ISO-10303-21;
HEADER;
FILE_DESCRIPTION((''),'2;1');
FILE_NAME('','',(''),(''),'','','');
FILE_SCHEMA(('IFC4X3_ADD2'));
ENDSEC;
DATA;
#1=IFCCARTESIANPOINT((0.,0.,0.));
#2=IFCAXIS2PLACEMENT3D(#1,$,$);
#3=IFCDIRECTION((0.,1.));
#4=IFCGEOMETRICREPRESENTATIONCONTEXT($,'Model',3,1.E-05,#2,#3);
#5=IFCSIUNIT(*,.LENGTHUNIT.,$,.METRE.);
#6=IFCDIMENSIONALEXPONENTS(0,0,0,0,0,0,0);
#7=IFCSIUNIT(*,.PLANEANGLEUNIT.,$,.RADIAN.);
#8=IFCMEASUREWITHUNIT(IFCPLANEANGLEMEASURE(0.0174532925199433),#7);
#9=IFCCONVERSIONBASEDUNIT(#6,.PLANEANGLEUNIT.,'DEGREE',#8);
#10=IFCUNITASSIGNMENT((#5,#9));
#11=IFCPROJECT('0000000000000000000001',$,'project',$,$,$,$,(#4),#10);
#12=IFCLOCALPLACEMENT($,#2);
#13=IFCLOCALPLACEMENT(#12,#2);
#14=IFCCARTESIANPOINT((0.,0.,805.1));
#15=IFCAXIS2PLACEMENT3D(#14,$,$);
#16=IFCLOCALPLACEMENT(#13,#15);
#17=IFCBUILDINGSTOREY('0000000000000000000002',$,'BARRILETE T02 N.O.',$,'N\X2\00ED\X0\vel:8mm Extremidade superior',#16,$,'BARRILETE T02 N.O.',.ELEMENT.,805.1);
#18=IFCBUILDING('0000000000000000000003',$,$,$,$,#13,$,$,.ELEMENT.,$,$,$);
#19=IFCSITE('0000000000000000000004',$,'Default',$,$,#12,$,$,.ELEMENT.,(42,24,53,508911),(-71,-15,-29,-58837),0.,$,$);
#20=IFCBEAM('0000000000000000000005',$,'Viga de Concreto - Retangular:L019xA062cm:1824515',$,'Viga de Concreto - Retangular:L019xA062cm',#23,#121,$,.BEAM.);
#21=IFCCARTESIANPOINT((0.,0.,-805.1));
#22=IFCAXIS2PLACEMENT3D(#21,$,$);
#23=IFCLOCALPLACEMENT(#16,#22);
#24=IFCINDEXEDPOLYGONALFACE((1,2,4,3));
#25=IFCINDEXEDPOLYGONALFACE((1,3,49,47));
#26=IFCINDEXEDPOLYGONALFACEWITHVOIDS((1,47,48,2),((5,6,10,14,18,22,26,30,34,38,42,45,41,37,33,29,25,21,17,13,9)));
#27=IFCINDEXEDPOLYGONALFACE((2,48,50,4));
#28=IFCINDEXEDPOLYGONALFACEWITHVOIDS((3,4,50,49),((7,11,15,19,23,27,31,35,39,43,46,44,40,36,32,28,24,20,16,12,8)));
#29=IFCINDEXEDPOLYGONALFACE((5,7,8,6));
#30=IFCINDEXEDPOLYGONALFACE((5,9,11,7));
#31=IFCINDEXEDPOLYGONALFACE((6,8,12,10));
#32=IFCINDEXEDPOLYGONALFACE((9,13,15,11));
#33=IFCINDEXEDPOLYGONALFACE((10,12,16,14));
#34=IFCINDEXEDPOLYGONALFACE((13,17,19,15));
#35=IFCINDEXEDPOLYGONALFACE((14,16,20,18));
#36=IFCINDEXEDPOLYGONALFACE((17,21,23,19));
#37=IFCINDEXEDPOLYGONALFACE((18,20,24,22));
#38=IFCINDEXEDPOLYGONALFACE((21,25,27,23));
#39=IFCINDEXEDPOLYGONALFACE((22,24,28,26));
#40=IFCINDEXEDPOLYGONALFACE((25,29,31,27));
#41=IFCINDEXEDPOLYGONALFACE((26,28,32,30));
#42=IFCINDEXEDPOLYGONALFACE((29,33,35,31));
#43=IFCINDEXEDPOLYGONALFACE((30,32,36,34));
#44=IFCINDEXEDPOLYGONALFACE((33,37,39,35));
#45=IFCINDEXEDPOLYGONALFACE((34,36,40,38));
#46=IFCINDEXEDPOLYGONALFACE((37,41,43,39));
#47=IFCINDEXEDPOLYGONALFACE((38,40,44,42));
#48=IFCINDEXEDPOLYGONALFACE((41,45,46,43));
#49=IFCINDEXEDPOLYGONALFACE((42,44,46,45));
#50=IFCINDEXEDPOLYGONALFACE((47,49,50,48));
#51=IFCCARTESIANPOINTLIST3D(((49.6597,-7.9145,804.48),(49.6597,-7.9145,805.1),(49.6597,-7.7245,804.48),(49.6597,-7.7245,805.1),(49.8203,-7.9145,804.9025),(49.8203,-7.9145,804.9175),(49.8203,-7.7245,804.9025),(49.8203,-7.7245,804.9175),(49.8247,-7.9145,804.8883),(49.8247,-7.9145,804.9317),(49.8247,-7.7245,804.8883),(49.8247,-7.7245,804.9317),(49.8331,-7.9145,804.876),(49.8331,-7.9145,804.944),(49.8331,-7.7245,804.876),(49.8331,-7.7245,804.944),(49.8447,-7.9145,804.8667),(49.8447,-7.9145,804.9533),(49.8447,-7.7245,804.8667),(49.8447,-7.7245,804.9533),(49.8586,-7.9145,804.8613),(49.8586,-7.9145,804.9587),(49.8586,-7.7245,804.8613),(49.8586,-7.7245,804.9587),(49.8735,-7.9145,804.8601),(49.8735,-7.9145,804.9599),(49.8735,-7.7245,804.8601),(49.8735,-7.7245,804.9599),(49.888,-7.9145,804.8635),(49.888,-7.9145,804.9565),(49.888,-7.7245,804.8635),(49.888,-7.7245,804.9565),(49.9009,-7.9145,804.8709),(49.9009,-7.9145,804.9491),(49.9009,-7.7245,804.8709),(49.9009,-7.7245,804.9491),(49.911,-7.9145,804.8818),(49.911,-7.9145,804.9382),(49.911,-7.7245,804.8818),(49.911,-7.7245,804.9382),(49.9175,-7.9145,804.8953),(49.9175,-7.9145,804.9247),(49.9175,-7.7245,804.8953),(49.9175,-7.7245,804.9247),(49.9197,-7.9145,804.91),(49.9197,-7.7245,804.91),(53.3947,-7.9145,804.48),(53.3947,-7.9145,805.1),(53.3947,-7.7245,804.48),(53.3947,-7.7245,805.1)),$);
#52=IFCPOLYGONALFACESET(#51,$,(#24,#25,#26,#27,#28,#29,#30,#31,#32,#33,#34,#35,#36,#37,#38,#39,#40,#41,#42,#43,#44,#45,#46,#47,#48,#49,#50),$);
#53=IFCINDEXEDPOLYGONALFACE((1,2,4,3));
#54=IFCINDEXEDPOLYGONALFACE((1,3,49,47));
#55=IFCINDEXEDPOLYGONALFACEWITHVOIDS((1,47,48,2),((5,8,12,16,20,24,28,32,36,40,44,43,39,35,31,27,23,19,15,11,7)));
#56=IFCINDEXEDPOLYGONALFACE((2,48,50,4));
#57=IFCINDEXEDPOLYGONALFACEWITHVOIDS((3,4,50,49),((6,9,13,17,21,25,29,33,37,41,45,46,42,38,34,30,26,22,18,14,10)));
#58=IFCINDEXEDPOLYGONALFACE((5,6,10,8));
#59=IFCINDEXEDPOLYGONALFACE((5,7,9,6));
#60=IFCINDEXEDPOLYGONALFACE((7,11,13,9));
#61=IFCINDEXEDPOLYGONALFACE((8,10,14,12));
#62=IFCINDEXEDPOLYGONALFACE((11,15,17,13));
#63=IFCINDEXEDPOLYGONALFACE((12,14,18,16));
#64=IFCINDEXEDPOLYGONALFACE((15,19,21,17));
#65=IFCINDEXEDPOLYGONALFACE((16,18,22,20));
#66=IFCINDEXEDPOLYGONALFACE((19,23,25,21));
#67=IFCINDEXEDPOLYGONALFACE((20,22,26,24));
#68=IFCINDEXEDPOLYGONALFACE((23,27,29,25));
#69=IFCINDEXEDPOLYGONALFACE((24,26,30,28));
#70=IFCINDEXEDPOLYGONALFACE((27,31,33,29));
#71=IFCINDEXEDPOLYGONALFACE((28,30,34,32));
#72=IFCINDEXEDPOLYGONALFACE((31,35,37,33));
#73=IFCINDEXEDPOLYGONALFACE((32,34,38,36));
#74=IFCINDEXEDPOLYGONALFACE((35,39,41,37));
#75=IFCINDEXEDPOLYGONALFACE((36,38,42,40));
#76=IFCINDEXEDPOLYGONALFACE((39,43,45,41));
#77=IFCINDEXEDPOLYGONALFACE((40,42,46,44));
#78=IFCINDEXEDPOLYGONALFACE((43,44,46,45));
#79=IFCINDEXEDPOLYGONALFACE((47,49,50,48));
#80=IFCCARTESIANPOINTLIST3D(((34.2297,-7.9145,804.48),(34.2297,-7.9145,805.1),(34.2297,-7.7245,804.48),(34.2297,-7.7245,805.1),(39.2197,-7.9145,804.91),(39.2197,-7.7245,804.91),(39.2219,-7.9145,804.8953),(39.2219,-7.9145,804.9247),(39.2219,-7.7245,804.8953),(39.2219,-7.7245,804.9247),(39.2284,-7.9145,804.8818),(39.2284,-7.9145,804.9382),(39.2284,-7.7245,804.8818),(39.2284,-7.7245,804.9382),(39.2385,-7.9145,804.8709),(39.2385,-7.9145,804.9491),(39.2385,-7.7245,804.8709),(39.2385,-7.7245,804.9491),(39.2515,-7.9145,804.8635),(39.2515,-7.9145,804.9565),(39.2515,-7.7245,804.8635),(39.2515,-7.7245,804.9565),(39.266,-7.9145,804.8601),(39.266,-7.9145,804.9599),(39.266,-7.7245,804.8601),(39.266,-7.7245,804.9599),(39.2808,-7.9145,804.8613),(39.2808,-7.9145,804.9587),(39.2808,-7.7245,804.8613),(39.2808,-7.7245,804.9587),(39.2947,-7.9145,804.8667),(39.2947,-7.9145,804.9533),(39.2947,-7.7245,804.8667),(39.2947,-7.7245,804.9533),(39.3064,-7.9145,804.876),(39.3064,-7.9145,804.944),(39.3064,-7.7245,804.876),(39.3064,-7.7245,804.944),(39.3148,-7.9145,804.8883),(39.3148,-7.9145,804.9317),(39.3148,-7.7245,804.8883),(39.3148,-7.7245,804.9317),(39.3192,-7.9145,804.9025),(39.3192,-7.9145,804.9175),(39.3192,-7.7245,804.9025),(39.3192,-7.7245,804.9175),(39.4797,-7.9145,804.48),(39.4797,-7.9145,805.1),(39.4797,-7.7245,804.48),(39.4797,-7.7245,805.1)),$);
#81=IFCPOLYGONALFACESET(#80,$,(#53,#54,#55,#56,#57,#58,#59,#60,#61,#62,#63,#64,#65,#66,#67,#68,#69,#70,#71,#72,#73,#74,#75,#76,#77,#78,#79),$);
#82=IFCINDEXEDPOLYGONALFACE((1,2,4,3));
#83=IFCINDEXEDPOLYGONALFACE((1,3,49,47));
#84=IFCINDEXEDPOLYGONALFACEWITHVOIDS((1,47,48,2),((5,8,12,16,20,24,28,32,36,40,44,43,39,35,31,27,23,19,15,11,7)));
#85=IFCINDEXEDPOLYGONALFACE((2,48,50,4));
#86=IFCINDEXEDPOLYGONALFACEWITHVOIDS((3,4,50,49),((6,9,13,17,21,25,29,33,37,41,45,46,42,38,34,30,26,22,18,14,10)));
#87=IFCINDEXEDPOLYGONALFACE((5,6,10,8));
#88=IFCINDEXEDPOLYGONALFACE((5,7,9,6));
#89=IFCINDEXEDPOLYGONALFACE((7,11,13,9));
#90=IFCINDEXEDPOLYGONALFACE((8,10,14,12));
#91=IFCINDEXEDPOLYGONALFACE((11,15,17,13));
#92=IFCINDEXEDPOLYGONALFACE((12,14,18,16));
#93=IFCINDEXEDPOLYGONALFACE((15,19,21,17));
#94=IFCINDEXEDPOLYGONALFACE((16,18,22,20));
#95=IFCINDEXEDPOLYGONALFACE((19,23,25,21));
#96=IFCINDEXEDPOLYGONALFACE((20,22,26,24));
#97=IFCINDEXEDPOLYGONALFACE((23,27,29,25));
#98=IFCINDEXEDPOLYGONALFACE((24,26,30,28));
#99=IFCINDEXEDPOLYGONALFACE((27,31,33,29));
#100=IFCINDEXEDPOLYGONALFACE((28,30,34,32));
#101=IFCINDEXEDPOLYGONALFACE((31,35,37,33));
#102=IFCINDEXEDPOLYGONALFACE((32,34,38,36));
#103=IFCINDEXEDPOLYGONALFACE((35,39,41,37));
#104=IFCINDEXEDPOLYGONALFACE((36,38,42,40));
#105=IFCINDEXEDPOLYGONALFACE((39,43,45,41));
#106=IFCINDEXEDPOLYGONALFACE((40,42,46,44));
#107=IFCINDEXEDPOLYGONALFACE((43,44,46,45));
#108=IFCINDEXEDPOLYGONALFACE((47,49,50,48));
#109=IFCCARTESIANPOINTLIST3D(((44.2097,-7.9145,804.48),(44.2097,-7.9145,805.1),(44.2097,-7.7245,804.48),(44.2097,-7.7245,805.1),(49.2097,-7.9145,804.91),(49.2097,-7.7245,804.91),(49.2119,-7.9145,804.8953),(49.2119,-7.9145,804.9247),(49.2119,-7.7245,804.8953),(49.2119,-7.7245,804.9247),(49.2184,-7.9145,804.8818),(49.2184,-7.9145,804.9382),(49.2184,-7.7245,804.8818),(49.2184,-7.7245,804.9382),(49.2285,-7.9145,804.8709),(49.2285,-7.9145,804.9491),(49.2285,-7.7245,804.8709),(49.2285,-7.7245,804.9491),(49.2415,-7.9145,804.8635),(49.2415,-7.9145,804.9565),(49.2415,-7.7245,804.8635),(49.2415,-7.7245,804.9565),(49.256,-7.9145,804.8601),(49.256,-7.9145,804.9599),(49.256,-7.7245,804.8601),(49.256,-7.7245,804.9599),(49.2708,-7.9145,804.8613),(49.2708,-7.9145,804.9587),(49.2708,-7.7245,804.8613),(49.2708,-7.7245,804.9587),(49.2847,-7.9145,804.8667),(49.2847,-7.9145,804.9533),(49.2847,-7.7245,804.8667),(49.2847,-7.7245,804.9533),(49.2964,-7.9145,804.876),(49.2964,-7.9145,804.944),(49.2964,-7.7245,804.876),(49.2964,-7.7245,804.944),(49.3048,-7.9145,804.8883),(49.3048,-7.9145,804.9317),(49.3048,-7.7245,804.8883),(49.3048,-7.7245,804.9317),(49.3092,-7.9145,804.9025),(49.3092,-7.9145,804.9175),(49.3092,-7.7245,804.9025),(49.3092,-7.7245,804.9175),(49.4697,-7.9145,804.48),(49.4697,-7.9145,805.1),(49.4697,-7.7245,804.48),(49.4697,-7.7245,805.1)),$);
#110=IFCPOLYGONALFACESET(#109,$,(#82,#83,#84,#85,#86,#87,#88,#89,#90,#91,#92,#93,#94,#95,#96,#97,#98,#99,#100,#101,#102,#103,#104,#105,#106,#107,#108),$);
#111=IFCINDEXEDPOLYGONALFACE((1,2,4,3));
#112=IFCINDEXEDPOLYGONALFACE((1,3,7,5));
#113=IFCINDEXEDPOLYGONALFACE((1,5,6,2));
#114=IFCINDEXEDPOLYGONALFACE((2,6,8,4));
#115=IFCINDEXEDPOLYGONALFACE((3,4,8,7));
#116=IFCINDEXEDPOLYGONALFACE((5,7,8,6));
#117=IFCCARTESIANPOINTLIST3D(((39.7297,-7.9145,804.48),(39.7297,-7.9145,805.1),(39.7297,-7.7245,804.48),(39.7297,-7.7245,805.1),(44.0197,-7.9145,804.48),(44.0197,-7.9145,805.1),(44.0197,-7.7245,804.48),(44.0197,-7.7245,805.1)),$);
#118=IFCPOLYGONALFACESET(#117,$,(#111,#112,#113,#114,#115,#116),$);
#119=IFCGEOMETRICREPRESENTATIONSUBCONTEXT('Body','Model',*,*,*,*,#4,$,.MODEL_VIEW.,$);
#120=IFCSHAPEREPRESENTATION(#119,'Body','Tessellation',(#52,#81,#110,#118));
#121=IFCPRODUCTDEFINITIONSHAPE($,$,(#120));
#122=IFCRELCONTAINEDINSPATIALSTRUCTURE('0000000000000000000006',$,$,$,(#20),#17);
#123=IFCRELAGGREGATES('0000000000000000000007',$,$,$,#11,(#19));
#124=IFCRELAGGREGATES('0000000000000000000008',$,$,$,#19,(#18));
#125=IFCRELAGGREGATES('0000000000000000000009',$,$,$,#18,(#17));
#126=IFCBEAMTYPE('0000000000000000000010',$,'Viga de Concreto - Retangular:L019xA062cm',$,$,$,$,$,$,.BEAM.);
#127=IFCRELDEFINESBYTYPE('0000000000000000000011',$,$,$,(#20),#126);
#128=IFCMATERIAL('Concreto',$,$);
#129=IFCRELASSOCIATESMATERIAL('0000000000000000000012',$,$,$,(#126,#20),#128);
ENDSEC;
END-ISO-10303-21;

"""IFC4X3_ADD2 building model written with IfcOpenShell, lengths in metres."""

from ifc_helpers import new_model, entity, si_unit, converted_unit, direction, frame, frame_2d, origin, origin_2d_with_axis, place, context, subcontext, project, spatial, rectangle, circle, extrude, boolean, source, transform, mapped, material, material_profile, profile_set, type_object, type_shapes, element, save


model = new_model("IFC4X3_ADD2")

# Units and contexts
model_context = context("Model", 3, precision=1e-05, world=origin(), true_north=direction((0.0, 1.0)))
body_context = subcontext(model_context, "Body", "Model", "MODEL_VIEW")
ifc_project = project(units=[si_unit("LENGTHUNIT", "METRE"), converted_unit("PLANEANGLEUNIT", "DEGREE", entity("IfcPlaneAngleMeasure", 0.0174532925199433), si_unit("PLANEANGLEUNIT", "RADIAN"), dimensions=[0, 0, 0, 0, 0, 0, 0])], contexts=[model_context])

# Site, building, storey
site_placement = place(None, origin())
site = spatial("IfcSite", under=ifc_project, at=site_placement, Name="Default", CompositionType="ELEMENT", RefLatitude=(42, 24, 53, 508911), RefLongitude=(-71, -15, -29, -58837), RefElevation=0.0)
building_placement = place(site_placement, origin())
building = spatial("IfcBuilding", under=site, at=building_placement, CompositionType="ELEMENT")
storey_placement = place(building_placement, frame((0.0, 0.0, 805.1)))
storey = spatial("IfcBuildingStorey", under=building, at=storey_placement, Name="BARRILETE T02 N.O.", ObjectType="Nível:8mm Extremidade superior", LongName="BARRILETE T02 N.O.", CompositionType="ELEMENT", Elevation=805.1)

# Beam
ifc_material = material(Name="Concreto")
ifc_material_profile_1 = material_profile(ifc_material, rectangle(XDim=0.62, YDim=0.19, at=frame_2d((0.0, 0.0), x_axis=(0.0, 1.0))), Name="L019xA062cm")
ifc_profile_set_1 = profile_set([ifc_material_profile_1], Name="L019xA062cm")
beam_type_1 = type_object("IfcBeamType", Name="Viga de Concreto - Retangular:L019xA062cm", PredefinedType="BEAM", material=ifc_profile_set_1)
shared_shape_1 = source(origin(), body_context, "Body", "SweptSolid", [
    boolean("DIFFERENCE", extrude(rectangle(XDim=0.62, YDim=0.19, at=frame_2d((0.0, 0.0), x_axis=(0.0, 1.0))), frame((49.6597, -7.8195, 804.79), z_axis=(1.0, 0.0, 0.0), x_axis=(0.0, 1.0, 0.0)), (0.0, 0.0, 1.0), 3.735), extrude(circle(Radius=0.05, at=origin_2d_with_axis()), frame((49.8697, -7.9145, 804.91), z_axis=(0.0, 1.0, 0.0), x_axis=(1.0, 0.0, 0.0)), (0.0, 0.0, 1.0), 0.19)),
    boolean("DIFFERENCE", extrude(rectangle(XDim=0.62, YDim=0.19, at=frame_2d((0.0, 0.0), x_axis=(0.0, 1.0))), frame((34.2297, -7.8195, 804.79), z_axis=(1.0, 0.0, 0.0), x_axis=(0.0, 1.0, 0.0)), (0.0, 0.0, 1.0), 5.25), extrude(circle(Radius=0.05, at=origin_2d_with_axis()), frame((39.2697, -7.9145, 804.91), z_axis=(0.0, 1.0, 0.0), x_axis=(-1.0, 0.0, 0.0)), (0.0, 0.0, 1.0), 0.19)),
    boolean("DIFFERENCE", extrude(rectangle(XDim=0.62, YDim=0.19, at=frame_2d((0.0, 0.0), x_axis=(0.0, 1.0))), frame((44.2097, -7.8195, 804.79), z_axis=(1.0, 0.0, 0.0), x_axis=(0.0, 1.0, 0.0)), (0.0, 0.0, 1.0), 5.26), extrude(circle(Radius=0.05, at=origin_2d_with_axis()), frame((49.2597, -7.9145, 804.91), z_axis=(0.0, 1.0, 0.0), x_axis=(-1.0, 0.0, 0.0)), (0.0, 0.0, 1.0), 0.19)),
    extrude(rectangle(XDim=0.62, YDim=0.19, at=frame_2d((0.0, 0.0), x_axis=(1.0, 0.0))), frame((39.7297, -7.8195, 804.79), z_axis=(1.0, 0.0, 0.0), x_axis=(0.0, 0.0, -1.0)), (0.0, 0.0, 1.0), 4.29),
])
type_shapes(beam_type_1, [shared_shape_1])
beam_1_placement = place(storey_placement, frame((0.0, 0.0, -805.1)))
element("IfcBeam", 1, at=beam_1_placement, inside=storey, type_object=beam_type_1, material=ifc_material, Name="Viga de Concreto - Retangular:L019xA062cm:1824515", ObjectType="Viga de Concreto - Retangular:L019xA062cm", PredefinedType="BEAM", context=body_context, shape_type="MappedRepresentation", body=[
    mapped(shared_shape_1, transform((0.0, 0.0, 0.0), scale=1.0)),
])

save(model, "model.ifc")
